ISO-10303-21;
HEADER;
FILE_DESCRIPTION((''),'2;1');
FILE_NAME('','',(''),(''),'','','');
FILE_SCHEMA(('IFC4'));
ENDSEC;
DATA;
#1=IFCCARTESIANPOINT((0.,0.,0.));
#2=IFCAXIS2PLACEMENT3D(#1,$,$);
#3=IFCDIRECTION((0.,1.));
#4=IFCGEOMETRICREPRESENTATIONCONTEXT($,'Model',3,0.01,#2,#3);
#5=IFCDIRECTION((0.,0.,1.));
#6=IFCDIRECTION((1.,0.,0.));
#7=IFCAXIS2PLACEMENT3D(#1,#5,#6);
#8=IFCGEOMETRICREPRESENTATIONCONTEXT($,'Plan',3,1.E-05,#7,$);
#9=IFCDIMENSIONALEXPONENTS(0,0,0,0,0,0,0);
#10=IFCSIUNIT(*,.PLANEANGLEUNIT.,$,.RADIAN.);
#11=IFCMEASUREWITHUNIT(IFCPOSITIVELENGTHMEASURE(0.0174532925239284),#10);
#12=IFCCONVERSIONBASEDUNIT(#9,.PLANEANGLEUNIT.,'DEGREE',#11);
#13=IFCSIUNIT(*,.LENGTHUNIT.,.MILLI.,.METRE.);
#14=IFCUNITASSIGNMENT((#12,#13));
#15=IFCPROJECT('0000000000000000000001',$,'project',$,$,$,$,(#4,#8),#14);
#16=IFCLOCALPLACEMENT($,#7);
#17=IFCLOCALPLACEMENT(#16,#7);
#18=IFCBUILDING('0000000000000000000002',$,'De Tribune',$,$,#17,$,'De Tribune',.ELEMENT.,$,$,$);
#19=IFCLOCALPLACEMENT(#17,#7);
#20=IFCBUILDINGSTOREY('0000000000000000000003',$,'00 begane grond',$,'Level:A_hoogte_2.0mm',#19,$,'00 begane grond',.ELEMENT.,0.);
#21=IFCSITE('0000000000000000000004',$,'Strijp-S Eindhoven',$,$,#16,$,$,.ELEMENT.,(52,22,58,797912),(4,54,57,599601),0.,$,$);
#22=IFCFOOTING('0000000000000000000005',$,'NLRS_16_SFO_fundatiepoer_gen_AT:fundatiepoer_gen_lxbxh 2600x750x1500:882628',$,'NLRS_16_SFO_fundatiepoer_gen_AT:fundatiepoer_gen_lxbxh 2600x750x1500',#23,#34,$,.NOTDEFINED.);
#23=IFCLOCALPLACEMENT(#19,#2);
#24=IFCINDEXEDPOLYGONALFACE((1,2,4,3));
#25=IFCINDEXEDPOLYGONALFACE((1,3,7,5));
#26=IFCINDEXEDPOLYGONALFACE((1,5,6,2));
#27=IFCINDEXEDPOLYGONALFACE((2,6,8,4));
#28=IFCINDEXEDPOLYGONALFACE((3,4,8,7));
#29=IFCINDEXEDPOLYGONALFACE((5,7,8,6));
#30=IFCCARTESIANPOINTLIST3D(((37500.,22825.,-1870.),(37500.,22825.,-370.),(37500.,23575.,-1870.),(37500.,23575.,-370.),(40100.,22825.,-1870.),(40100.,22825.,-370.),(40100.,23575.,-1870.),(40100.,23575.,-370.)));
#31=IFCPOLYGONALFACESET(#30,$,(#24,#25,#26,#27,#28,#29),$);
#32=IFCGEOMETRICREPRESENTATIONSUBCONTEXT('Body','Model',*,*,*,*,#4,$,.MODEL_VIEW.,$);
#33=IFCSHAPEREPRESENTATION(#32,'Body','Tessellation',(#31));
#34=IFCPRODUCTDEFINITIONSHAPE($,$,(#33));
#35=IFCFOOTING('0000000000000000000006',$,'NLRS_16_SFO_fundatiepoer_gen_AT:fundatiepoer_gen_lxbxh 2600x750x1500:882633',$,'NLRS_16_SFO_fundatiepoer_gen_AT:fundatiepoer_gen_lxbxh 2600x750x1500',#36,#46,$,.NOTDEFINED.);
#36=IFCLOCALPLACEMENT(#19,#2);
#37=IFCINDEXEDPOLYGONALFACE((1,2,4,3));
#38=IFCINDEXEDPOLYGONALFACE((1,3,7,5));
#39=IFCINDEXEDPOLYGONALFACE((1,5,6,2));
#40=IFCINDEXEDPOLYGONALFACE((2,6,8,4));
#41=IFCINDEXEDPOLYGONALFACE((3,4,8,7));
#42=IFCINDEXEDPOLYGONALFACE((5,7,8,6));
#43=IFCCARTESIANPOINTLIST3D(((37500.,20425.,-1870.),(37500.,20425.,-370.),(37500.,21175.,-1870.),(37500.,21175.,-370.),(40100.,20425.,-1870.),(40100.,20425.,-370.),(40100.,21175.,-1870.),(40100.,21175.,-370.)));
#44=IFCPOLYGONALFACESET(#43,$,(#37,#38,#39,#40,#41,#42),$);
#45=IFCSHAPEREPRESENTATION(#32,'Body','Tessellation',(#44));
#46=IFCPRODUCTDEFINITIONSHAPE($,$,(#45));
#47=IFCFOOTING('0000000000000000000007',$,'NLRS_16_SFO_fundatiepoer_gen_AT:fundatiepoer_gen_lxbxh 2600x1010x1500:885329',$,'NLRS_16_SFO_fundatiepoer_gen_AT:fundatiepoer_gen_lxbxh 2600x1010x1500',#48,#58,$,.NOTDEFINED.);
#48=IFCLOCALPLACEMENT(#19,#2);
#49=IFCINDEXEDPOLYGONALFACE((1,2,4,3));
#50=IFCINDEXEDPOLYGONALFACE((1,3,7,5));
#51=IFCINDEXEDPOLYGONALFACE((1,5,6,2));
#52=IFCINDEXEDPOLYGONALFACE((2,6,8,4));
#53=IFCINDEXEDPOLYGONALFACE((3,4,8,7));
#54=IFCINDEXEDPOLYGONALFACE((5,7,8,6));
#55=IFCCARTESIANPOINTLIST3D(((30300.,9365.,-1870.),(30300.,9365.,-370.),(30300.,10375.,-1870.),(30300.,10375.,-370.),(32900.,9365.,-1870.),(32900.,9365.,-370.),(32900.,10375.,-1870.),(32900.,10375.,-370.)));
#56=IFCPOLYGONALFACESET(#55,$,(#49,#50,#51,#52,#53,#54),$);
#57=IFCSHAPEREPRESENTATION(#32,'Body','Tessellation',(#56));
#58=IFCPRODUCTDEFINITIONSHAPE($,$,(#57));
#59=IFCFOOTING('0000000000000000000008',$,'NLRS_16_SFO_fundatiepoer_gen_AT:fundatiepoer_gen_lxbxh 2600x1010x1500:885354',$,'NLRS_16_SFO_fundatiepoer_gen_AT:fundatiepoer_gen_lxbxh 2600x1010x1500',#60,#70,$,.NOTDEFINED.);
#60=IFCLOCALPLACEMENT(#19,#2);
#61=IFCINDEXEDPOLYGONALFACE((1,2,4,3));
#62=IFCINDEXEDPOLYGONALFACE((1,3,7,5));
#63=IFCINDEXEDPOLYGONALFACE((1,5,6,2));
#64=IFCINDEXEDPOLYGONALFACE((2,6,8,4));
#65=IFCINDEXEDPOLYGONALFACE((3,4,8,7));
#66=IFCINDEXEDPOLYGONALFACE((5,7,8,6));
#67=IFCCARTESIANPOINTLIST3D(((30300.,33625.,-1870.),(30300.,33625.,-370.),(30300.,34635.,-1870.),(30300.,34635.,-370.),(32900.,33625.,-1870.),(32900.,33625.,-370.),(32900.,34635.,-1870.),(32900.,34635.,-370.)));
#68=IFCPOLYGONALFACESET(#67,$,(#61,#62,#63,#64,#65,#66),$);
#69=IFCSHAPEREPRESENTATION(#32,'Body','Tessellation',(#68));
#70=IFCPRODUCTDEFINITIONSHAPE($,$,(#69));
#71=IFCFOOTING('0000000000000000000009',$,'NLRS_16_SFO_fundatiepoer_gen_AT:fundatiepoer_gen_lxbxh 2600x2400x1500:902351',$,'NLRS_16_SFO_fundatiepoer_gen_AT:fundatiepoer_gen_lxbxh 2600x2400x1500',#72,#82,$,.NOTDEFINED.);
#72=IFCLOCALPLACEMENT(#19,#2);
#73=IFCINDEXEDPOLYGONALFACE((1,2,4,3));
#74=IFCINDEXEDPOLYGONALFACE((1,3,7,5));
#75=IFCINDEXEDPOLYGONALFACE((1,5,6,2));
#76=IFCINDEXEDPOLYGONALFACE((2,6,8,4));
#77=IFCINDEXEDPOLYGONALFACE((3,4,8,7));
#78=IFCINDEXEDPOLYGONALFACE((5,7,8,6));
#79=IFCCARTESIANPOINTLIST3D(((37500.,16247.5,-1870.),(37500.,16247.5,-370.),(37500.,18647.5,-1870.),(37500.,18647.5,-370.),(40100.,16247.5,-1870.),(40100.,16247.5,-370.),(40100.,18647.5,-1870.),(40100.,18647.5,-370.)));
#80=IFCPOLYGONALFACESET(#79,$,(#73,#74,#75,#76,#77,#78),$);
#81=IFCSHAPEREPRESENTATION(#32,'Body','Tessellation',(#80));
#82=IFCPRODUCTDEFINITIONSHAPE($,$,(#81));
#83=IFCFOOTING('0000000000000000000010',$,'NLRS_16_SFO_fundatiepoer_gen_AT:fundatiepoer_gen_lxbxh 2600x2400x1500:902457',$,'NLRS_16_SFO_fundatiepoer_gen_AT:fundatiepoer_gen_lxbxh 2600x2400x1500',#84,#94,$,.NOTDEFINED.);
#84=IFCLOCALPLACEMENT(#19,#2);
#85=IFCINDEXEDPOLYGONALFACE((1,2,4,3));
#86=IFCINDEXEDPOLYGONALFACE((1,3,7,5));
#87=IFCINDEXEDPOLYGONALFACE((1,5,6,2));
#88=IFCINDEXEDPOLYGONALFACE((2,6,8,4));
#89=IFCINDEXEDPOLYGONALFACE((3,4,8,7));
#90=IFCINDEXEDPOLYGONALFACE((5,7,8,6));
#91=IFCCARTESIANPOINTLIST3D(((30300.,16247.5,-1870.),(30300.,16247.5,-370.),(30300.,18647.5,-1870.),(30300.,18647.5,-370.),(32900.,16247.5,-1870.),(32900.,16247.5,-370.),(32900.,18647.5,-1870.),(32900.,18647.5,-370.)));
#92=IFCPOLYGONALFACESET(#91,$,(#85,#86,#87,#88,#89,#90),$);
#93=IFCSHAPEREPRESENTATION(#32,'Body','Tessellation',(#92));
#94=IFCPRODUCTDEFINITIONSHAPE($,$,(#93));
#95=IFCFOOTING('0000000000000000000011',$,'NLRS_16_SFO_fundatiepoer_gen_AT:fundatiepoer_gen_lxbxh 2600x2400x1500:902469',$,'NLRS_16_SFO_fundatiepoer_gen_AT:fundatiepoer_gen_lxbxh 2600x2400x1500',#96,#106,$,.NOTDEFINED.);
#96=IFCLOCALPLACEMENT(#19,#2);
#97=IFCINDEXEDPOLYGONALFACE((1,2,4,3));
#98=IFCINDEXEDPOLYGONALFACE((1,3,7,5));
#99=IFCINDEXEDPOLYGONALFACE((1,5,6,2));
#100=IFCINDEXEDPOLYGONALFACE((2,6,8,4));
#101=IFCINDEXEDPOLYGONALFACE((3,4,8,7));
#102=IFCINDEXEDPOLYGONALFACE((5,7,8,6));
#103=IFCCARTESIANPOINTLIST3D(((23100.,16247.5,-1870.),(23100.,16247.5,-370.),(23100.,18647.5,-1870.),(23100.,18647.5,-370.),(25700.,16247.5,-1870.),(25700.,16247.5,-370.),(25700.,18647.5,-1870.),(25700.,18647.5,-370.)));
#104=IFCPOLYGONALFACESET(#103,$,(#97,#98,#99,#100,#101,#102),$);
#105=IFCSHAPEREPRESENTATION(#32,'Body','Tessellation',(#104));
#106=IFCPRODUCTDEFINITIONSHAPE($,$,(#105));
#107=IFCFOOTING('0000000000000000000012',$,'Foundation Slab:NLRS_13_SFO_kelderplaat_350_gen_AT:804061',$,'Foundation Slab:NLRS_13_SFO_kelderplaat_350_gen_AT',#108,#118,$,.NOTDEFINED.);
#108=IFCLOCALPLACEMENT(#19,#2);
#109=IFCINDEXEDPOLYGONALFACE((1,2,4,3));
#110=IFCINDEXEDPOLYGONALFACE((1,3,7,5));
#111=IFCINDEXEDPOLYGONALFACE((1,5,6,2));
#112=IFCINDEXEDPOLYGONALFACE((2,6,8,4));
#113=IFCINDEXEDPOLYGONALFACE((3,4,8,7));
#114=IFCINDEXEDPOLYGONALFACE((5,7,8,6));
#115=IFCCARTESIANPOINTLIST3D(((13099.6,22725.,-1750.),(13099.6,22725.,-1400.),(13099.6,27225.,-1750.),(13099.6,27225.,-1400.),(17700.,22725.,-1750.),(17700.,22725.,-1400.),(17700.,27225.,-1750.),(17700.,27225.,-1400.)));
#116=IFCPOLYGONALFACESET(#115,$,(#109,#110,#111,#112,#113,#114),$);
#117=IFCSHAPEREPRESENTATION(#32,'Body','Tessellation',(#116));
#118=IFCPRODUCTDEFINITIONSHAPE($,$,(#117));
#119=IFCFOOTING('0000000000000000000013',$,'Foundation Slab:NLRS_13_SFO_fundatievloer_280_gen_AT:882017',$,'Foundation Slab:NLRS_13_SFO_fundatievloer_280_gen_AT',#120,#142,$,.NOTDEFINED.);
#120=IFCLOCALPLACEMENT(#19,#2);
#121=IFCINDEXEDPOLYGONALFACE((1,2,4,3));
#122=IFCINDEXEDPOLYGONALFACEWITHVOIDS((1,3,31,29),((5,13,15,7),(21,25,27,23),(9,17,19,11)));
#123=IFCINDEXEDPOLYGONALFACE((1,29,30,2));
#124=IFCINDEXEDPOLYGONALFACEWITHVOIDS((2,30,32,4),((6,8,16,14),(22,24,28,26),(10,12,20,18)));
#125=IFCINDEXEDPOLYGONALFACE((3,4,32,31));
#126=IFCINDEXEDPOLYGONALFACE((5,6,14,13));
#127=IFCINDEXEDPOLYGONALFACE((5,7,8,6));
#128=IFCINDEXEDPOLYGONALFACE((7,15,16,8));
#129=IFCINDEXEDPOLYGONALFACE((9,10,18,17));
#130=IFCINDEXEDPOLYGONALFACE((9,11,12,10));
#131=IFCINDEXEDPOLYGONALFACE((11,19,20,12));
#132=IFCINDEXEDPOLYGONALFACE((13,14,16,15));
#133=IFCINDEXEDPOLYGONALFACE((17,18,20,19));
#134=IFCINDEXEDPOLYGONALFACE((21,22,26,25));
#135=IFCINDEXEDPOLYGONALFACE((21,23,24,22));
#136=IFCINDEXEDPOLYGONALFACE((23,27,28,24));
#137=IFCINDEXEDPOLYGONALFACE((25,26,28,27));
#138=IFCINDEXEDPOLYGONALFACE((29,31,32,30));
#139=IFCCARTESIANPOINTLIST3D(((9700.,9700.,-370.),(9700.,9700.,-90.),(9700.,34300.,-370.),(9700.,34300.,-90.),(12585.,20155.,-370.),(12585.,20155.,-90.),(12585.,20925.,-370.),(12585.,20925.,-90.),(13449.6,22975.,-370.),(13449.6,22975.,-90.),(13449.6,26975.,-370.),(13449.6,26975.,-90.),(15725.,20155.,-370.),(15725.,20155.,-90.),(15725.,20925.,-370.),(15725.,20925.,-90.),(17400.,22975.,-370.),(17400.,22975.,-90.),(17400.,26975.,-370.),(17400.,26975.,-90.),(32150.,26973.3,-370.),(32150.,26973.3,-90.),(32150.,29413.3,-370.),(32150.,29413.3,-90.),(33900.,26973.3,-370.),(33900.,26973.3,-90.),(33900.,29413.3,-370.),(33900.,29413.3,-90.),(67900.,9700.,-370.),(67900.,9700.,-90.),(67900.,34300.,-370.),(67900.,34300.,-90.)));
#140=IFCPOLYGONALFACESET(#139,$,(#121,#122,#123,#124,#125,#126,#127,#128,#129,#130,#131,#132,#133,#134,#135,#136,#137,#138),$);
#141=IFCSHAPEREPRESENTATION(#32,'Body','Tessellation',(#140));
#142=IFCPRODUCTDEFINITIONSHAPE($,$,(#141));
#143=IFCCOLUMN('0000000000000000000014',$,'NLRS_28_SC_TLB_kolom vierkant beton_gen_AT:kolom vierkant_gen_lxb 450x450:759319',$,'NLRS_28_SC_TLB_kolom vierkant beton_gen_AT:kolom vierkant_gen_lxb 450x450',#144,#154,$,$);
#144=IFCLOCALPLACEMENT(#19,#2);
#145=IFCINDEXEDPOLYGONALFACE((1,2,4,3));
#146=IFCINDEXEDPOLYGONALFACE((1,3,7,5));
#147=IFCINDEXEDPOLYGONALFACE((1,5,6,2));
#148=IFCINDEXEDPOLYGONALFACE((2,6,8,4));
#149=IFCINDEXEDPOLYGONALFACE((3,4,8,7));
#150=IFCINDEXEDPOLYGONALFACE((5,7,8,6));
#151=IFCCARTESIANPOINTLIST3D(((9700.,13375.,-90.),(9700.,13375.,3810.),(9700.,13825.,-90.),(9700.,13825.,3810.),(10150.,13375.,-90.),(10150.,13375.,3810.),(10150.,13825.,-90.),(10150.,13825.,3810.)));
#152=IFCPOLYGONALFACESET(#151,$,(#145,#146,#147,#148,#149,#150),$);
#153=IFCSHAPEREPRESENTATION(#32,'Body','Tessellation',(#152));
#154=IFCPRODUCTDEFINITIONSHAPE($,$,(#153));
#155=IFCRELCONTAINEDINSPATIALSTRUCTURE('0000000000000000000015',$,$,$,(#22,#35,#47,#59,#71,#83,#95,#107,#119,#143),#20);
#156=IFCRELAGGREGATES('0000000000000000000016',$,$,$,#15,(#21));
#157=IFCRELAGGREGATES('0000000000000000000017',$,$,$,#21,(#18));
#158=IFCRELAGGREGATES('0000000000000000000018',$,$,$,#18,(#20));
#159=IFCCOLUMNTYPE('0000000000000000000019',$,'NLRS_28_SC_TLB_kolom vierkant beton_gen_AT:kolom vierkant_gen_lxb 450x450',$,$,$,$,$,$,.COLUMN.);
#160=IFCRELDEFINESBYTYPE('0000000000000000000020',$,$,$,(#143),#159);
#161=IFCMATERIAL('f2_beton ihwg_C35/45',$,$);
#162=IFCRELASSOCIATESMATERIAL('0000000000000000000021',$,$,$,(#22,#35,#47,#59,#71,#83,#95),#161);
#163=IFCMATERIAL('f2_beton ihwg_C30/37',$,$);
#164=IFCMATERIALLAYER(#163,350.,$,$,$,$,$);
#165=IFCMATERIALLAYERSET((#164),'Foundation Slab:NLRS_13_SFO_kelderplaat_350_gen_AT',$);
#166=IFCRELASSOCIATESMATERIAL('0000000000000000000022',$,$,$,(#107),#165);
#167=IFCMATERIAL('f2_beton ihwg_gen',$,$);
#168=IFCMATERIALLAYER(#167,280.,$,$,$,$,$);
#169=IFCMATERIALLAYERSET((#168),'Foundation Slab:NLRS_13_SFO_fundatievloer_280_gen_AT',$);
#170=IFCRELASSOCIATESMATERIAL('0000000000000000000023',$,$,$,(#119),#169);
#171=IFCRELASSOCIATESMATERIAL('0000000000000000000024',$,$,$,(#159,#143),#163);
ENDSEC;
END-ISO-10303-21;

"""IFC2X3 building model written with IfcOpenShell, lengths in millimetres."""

from ifc_helpers import new_model, entity, si_unit, converted_unit, direction, frame, frame_2d, origin, origin_with_axes, origin_2d_with_axis, place, context, subcontext, project, spatial, rectangle, extrude, boolean, source, transform, mapped, material, layer, layer_set, layer_usage, type_object, element, save


model = new_model("IFC2X3")

# Units and contexts
model_context = context("Model", 3, precision=0.01, world=origin(), true_north=direction((0.0, 1.0)))
plan_context = context("Plan", 3, precision=1e-05, world=origin_with_axes())
body_context = subcontext(model_context, "Body", "Model", "MODEL_VIEW")
ifc_project = project(units=[converted_unit("PLANEANGLEUNIT", "DEGREE", entity("IfcPositiveLengthMeasure", 0.0174532925239284), si_unit("PLANEANGLEUNIT", "RADIAN"), dimensions=[0, 0, 0, 0, 0, 0, 0]), si_unit("LENGTHUNIT", "METRE", prefix="MILLI")], contexts=[model_context, plan_context])

# Site, building, storey
site_placement = place(None, origin_with_axes())
site = spatial("IfcSite", under=ifc_project, at=site_placement, Name="Strijp-S Eindhoven", CompositionType="ELEMENT", RefLatitude=(52, 22, 58, 797912), RefLongitude=(4, 54, 57, 599601), RefElevation=0.0)
building_placement = place(site_placement, origin_with_axes())
building = spatial("IfcBuilding", under=site, at=building_placement, Name="De Tribune", LongName="De Tribune", CompositionType="ELEMENT")
storey_placement = place(building_placement, origin_with_axes())
storey = spatial("IfcBuildingStorey", under=building, at=storey_placement, Name="00 begane grond", ObjectType="Level:A_hoogte_2.0mm", LongName="00 begane grond", CompositionType="ELEMENT", Elevation=0.0)

# Footings
ifc_material_1 = material(Name="f2_beton ihwg_C35/45")
shared_shape_1 = source(origin(), body_context, "Body", "SweptSolid", [
    extrude(rectangle(XDim=750.0, YDim=2600.0, at=frame_2d((0.0, 0.0), x_axis=(1.0, 0.0))), frame((38800.0, 23200.0, -1870.0), z_axis=(0.0, 0.0, 1.0), x_axis=(0.0, -1.0, 0.0)), (0.0, 0.0, 1.0), 1500.0),
])
footing_1_placement = place(storey_placement, origin_with_axes())
element("IfcFooting", 1, at=footing_1_placement, inside=storey, material=ifc_material_1, Name="NLRS_16_SFO_fundatiepoer_gen_AT:fundatiepoer_gen_lxbxh 2600x750x1500:882628", ObjectType="NLRS_16_SFO_fundatiepoer_gen_AT:fundatiepoer_gen_lxbxh 2600x750x1500", PredefinedType="NOTDEFINED", context=body_context, shape_type="MappedRepresentation", body=[
    mapped(shared_shape_1, transform((0.0, 0.0, 0.0), scale=1.0)),
])
shared_shape_2 = source(origin(), body_context, "Body", "SweptSolid", [
    extrude(rectangle(XDim=750.0, YDim=2600.0, at=frame_2d((0.0, 0.0), x_axis=(1.0, 0.0))), frame((38800.0, 20800.0, -1870.0), z_axis=(0.0, 0.0, 1.0), x_axis=(0.0, -1.0, 0.0)), (0.0, 0.0, 1.0), 1500.0),
])
footing_2_placement = place(storey_placement, origin_with_axes())
element("IfcFooting", 2, at=footing_2_placement, inside=storey, material=ifc_material_1, Name="NLRS_16_SFO_fundatiepoer_gen_AT:fundatiepoer_gen_lxbxh 2600x750x1500:882633", ObjectType="NLRS_16_SFO_fundatiepoer_gen_AT:fundatiepoer_gen_lxbxh 2600x750x1500", PredefinedType="NOTDEFINED", context=body_context, shape_type="MappedRepresentation", body=[
    mapped(shared_shape_2, transform((0.0, 0.0, 0.0), scale=1.0)),
])
shared_shape_3 = source(origin(), body_context, "Body", "SweptSolid", [
    extrude(rectangle(XDim=1010.0, YDim=2600.0, at=origin_2d_with_axis()), frame((31600.0, 9870.0, -1870.0), z_axis=(0.0, 0.0, 1.0), x_axis=(0.0, -1.0, 0.0)), (0.0, 0.0, 1.0), 1500.0),
])
footing_3_placement = place(storey_placement, origin_with_axes())
element("IfcFooting", 3, at=footing_3_placement, inside=storey, material=ifc_material_1, Name="NLRS_16_SFO_fundatiepoer_gen_AT:fundatiepoer_gen_lxbxh 2600x1010x1500:885329", ObjectType="NLRS_16_SFO_fundatiepoer_gen_AT:fundatiepoer_gen_lxbxh 2600x1010x1500", PredefinedType="NOTDEFINED", context=body_context, shape_type="MappedRepresentation", body=[
    mapped(shared_shape_3, transform((0.0, 0.0, 0.0), scale=1.0)),
])
shared_shape_4 = source(origin(), body_context, "Body", "SweptSolid", [
    extrude(rectangle(XDim=1010.0, YDim=2600.0, at=frame_2d((0.0, 0.0), x_axis=(1.0, 0.0))), frame((31600.0, 34130.0, -1870.0), z_axis=(0.0, 0.0, 1.0), x_axis=(0.0, 1.0, 0.0)), (0.0, 0.0, 1.0), 1500.0),
])
footing_4_placement = place(storey_placement, origin_with_axes())
element("IfcFooting", 4, at=footing_4_placement, inside=storey, material=ifc_material_1, Name="NLRS_16_SFO_fundatiepoer_gen_AT:fundatiepoer_gen_lxbxh 2600x1010x1500:885354", ObjectType="NLRS_16_SFO_fundatiepoer_gen_AT:fundatiepoer_gen_lxbxh 2600x1010x1500", PredefinedType="NOTDEFINED", context=body_context, shape_type="MappedRepresentation", body=[
    mapped(shared_shape_4, transform((0.0, 0.0, 0.0), scale=1.0)),
])
shared_shape_5 = source(origin(), body_context, "Body", "SweptSolid", [
    extrude(rectangle(XDim=2400.0, YDim=2600.0, at=frame_2d((0.0, 0.0), x_axis=(1.0, 0.0))), frame((38800.0, 17447.5, -1870.0), z_axis=(0.0, 0.0, 1.0), x_axis=(0.0, 1.0, 0.0)), (0.0, 0.0, 1.0), 1500.0),
])
footing_5_placement = place(storey_placement, origin_with_axes())
element("IfcFooting", 5, at=footing_5_placement, inside=storey, material=ifc_material_1, Name="NLRS_16_SFO_fundatiepoer_gen_AT:fundatiepoer_gen_lxbxh 2600x2400x1500:902351", ObjectType="NLRS_16_SFO_fundatiepoer_gen_AT:fundatiepoer_gen_lxbxh 2600x2400x1500", PredefinedType="NOTDEFINED", context=body_context, shape_type="MappedRepresentation", body=[
    mapped(shared_shape_5, transform((0.0, 0.0, 0.0), scale=1.0)),
])
shared_shape_6 = source(origin(), body_context, "Body", "SweptSolid", [
    extrude(rectangle(XDim=2400.0, YDim=2600.0, at=frame_2d((0.0, 0.0), x_axis=(1.0, 0.0))), frame((31600.0, 17447.5, -1870.0), z_axis=(0.0, 0.0, 1.0), x_axis=(0.0, 1.0, 0.0)), (0.0, 0.0, 1.0), 1500.0),
])
footing_6_placement = place(storey_placement, origin_with_axes())
element("IfcFooting", 6, at=footing_6_placement, inside=storey, material=ifc_material_1, Name="NLRS_16_SFO_fundatiepoer_gen_AT:fundatiepoer_gen_lxbxh 2600x2400x1500:902457", ObjectType="NLRS_16_SFO_fundatiepoer_gen_AT:fundatiepoer_gen_lxbxh 2600x2400x1500", PredefinedType="NOTDEFINED", context=body_context, shape_type="MappedRepresentation", body=[
    mapped(shared_shape_6, transform((0.0, 0.0, 0.0), scale=1.0)),
])
shared_shape_7 = source(origin(), body_context, "Body", "SweptSolid", [
    extrude(rectangle(XDim=2400.0, YDim=2600.0, at=frame_2d((0.0, 0.0), x_axis=(1.0, 0.0))), frame((24400.0, 17447.5, -1870.0), z_axis=(0.0, 0.0, 1.0), x_axis=(0.0, 1.0, 0.0)), (0.0, 0.0, 1.0), 1500.0),
])
footing_7_placement = place(storey_placement, origin_with_axes())
element("IfcFooting", 7, at=footing_7_placement, inside=storey, material=ifc_material_1, Name="NLRS_16_SFO_fundatiepoer_gen_AT:fundatiepoer_gen_lxbxh 2600x2400x1500:902469", ObjectType="NLRS_16_SFO_fundatiepoer_gen_AT:fundatiepoer_gen_lxbxh 2600x2400x1500", PredefinedType="NOTDEFINED", context=body_context, shape_type="MappedRepresentation", body=[
    mapped(shared_shape_7, transform((0.0, 0.0, 0.0), scale=1.0)),
])
ifc_material_2 = material(Name="f2_beton ihwg_C30/37")
ifc_layer_1 = layer(ifc_material_2, 350.0)
ifc_layer_set_1 = layer_set([ifc_layer_1], Name="Foundation Slab:NLRS_13_SFO_kelderplaat_350_gen_AT")
ifc_layer_usage_1 = layer_usage(ifc_layer_set_1, "AXIS3", "POSITIVE", 0.0)
footing_8_placement = place(storey_placement, origin_with_axes())
element("IfcFooting", 8, at=footing_8_placement, inside=storey, material=ifc_layer_usage_1, Name="Foundation Slab:NLRS_13_SFO_kelderplaat_350_gen_AT:804061", ObjectType="Foundation Slab:NLRS_13_SFO_kelderplaat_350_gen_AT", PredefinedType="NOTDEFINED", context=body_context, shape_type="SweptSolid", body=[
    extrude(rectangle(XDim=4500.0, YDim=4600.4, at=origin_2d_with_axis()), frame((15399.8, 24975.0, -1400.0), z_axis=(0.0, 0.0, -1.0), x_axis=(0.0, 1.0, 0.0)), (0.0, 0.0, 1.0), 350.0),
])

# Footing, openings
ifc_material_3 = material(Name="f2_beton ihwg_gen")
ifc_layer_2 = layer(ifc_material_3, 280.0)
ifc_layer_set_2 = layer_set([ifc_layer_2], Name="Foundation Slab:NLRS_13_SFO_fundatievloer_280_gen_AT")
ifc_layer_usage_2 = layer_usage(ifc_layer_set_2, "AXIS3", "POSITIVE", 0.0)
footing_9_placement = place(storey_placement, origin_with_axes())
footing_9 = element("IfcFooting", 9, at=footing_9_placement, inside=storey, material=ifc_layer_usage_2, Name="Foundation Slab:NLRS_13_SFO_fundatievloer_280_gen_AT:882017", ObjectType="Foundation Slab:NLRS_13_SFO_fundatievloer_280_gen_AT", PredefinedType="NOTDEFINED", context=body_context, shape_type="SweptSolid", body=[
    boolean("DIFFERENCE", boolean("DIFFERENCE", boolean("DIFFERENCE", extrude(rectangle(XDim=24600.0, YDim=58200.0, at=frame_2d((0.0, 0.0), x_axis=(1.0, 0.0))), frame((38800.0, 22000.0, -90.0), z_axis=(0.0, 0.0, -1.0), x_axis=(0.0, 1.0, 0.0)), (0.0, 0.0, 1.0), 280.0), extrude(rectangle(XDim=770.0, YDim=3140.0, at=origin_2d_with_axis()), frame((14155.0, 20540.0, -370.0), z_axis=(0.0, 0.0, 1.0), x_axis=(0.0, 1.0, 0.0)), (0.0, 0.0, 1.0), 280.0)), extrude(rectangle(XDim=4000.0, YDim=3950.4, at=origin_2d_with_axis()), frame((15424.8, 24975.0, -90.0), z_axis=(0.0, 0.0, -1.0), x_axis=(0.0, -1.0, 0.0)), (0.0, 0.0, 1.0), 280.0)), extrude(rectangle(XDim=2440.0, YDim=1750.0, at=frame_2d((0.0, 0.0), x_axis=(1.0, 0.0))), frame((33025.0, 28193.3, -370.0), z_axis=(0.0, 0.0, 1.0), x_axis=(0.0, 1.0, 0.0)), (0.0, 0.0, 1.0), 280.0)),
])
opening_1_placement = place(footing_9_placement, origin_with_axes())
element("IfcOpeningElement", 10, at=opening_1_placement, cuts=footing_9, ObjectType="Opening", context=body_context, shape_type="SweptSolid", body=[
    extrude(rectangle(XDim=4000.0, YDim=3950.4, at=origin_2d_with_axis()), frame((15424.8, 24975.0, -370.0), z_axis=(0.0, 0.0, 1.0), x_axis=(0.0, 1.0, 0.0)), (0.0, 0.0, 1.0), 280.0),
])
opening_2_placement = place(footing_9_placement, origin_with_axes())
element("IfcOpeningElement", 11, at=opening_2_placement, cuts=footing_9, ObjectType="Opening", context=body_context, shape_type="SweptSolid", body=[
    extrude(rectangle(XDim=1750.0, YDim=2440.0, at=frame_2d((0.0, 0.0), x_axis=(1.0, 0.0))), frame((33025.0, 28193.3, -90.0), z_axis=(0.0, 0.0, -1.0), x_axis=(1.0, 0.0, 0.0)), (0.0, 0.0, 1.0), 280.0),
])
opening_3_placement = place(footing_9_placement, origin_with_axes())
element("IfcOpeningElement", 12, at=opening_3_placement, cuts=footing_9, ObjectType="Opening", context=body_context, shape_type="SweptSolid", body=[
    extrude(rectangle(XDim=3300.4, YDim=3500.0, at=origin_2d_with_axis()), frame((15299.8, 24925.0, -90.0), z_axis=(0.0, 0.0, -1.0), x_axis=(1.0, 0.0, 0.0)), (0.0, 0.0, 1.0), 280.0),
])
opening_4_placement = place(footing_9_placement, origin_with_axes())
element("IfcOpeningElement", 13, at=opening_4_placement, cuts=footing_9, ObjectType="Opening", context=body_context, shape_type="SweptSolid", body=[
    extrude(rectangle(XDim=770.0, YDim=3140.0, at=frame_2d((0.0, 0.0), x_axis=(1.0, 0.0))), frame((14155.0, 20540.0, -90.0), z_axis=(0.0, 0.0, -1.0), x_axis=(0.0, -1.0, 0.0)), (0.0, 0.0, 1.0), 280.0),
])

# Column
column_type = type_object("IfcColumnType", Name="NLRS_28_SC_TLB_kolom vierkant beton_gen_AT:kolom vierkant_gen_lxb 450x450", PredefinedType="COLUMN", material=ifc_material_2)
shared_shape_8 = source(origin(), body_context, "Body", "SweptSolid", [
    extrude(rectangle(XDim=450.0, YDim=450.0, at=frame_2d((0.0, 0.0), x_axis=(1.0, 0.0))), frame((9925.0, 13600.0, -90.0), z_axis=(0.0, 0.0, 1.0), x_axis=(-1.0, 0.0, 0.0)), (0.0, 0.0, 1.0), 3900.0),
])
column_placement = place(storey_placement, origin_with_axes())
element("IfcColumn", 14, at=column_placement, inside=storey, type_object=column_type, material=ifc_material_2, Name="NLRS_28_SC_TLB_kolom vierkant beton_gen_AT:kolom vierkant_gen_lxb 450x450:759319", ObjectType="NLRS_28_SC_TLB_kolom vierkant beton_gen_AT:kolom vierkant_gen_lxb 450x450", context=body_context, shape_type="MappedRepresentation", body=[
    mapped(shared_shape_8, transform((0.0, 0.0, 0.0), scale=1.0)),
])

save(model, "model.ifc")
